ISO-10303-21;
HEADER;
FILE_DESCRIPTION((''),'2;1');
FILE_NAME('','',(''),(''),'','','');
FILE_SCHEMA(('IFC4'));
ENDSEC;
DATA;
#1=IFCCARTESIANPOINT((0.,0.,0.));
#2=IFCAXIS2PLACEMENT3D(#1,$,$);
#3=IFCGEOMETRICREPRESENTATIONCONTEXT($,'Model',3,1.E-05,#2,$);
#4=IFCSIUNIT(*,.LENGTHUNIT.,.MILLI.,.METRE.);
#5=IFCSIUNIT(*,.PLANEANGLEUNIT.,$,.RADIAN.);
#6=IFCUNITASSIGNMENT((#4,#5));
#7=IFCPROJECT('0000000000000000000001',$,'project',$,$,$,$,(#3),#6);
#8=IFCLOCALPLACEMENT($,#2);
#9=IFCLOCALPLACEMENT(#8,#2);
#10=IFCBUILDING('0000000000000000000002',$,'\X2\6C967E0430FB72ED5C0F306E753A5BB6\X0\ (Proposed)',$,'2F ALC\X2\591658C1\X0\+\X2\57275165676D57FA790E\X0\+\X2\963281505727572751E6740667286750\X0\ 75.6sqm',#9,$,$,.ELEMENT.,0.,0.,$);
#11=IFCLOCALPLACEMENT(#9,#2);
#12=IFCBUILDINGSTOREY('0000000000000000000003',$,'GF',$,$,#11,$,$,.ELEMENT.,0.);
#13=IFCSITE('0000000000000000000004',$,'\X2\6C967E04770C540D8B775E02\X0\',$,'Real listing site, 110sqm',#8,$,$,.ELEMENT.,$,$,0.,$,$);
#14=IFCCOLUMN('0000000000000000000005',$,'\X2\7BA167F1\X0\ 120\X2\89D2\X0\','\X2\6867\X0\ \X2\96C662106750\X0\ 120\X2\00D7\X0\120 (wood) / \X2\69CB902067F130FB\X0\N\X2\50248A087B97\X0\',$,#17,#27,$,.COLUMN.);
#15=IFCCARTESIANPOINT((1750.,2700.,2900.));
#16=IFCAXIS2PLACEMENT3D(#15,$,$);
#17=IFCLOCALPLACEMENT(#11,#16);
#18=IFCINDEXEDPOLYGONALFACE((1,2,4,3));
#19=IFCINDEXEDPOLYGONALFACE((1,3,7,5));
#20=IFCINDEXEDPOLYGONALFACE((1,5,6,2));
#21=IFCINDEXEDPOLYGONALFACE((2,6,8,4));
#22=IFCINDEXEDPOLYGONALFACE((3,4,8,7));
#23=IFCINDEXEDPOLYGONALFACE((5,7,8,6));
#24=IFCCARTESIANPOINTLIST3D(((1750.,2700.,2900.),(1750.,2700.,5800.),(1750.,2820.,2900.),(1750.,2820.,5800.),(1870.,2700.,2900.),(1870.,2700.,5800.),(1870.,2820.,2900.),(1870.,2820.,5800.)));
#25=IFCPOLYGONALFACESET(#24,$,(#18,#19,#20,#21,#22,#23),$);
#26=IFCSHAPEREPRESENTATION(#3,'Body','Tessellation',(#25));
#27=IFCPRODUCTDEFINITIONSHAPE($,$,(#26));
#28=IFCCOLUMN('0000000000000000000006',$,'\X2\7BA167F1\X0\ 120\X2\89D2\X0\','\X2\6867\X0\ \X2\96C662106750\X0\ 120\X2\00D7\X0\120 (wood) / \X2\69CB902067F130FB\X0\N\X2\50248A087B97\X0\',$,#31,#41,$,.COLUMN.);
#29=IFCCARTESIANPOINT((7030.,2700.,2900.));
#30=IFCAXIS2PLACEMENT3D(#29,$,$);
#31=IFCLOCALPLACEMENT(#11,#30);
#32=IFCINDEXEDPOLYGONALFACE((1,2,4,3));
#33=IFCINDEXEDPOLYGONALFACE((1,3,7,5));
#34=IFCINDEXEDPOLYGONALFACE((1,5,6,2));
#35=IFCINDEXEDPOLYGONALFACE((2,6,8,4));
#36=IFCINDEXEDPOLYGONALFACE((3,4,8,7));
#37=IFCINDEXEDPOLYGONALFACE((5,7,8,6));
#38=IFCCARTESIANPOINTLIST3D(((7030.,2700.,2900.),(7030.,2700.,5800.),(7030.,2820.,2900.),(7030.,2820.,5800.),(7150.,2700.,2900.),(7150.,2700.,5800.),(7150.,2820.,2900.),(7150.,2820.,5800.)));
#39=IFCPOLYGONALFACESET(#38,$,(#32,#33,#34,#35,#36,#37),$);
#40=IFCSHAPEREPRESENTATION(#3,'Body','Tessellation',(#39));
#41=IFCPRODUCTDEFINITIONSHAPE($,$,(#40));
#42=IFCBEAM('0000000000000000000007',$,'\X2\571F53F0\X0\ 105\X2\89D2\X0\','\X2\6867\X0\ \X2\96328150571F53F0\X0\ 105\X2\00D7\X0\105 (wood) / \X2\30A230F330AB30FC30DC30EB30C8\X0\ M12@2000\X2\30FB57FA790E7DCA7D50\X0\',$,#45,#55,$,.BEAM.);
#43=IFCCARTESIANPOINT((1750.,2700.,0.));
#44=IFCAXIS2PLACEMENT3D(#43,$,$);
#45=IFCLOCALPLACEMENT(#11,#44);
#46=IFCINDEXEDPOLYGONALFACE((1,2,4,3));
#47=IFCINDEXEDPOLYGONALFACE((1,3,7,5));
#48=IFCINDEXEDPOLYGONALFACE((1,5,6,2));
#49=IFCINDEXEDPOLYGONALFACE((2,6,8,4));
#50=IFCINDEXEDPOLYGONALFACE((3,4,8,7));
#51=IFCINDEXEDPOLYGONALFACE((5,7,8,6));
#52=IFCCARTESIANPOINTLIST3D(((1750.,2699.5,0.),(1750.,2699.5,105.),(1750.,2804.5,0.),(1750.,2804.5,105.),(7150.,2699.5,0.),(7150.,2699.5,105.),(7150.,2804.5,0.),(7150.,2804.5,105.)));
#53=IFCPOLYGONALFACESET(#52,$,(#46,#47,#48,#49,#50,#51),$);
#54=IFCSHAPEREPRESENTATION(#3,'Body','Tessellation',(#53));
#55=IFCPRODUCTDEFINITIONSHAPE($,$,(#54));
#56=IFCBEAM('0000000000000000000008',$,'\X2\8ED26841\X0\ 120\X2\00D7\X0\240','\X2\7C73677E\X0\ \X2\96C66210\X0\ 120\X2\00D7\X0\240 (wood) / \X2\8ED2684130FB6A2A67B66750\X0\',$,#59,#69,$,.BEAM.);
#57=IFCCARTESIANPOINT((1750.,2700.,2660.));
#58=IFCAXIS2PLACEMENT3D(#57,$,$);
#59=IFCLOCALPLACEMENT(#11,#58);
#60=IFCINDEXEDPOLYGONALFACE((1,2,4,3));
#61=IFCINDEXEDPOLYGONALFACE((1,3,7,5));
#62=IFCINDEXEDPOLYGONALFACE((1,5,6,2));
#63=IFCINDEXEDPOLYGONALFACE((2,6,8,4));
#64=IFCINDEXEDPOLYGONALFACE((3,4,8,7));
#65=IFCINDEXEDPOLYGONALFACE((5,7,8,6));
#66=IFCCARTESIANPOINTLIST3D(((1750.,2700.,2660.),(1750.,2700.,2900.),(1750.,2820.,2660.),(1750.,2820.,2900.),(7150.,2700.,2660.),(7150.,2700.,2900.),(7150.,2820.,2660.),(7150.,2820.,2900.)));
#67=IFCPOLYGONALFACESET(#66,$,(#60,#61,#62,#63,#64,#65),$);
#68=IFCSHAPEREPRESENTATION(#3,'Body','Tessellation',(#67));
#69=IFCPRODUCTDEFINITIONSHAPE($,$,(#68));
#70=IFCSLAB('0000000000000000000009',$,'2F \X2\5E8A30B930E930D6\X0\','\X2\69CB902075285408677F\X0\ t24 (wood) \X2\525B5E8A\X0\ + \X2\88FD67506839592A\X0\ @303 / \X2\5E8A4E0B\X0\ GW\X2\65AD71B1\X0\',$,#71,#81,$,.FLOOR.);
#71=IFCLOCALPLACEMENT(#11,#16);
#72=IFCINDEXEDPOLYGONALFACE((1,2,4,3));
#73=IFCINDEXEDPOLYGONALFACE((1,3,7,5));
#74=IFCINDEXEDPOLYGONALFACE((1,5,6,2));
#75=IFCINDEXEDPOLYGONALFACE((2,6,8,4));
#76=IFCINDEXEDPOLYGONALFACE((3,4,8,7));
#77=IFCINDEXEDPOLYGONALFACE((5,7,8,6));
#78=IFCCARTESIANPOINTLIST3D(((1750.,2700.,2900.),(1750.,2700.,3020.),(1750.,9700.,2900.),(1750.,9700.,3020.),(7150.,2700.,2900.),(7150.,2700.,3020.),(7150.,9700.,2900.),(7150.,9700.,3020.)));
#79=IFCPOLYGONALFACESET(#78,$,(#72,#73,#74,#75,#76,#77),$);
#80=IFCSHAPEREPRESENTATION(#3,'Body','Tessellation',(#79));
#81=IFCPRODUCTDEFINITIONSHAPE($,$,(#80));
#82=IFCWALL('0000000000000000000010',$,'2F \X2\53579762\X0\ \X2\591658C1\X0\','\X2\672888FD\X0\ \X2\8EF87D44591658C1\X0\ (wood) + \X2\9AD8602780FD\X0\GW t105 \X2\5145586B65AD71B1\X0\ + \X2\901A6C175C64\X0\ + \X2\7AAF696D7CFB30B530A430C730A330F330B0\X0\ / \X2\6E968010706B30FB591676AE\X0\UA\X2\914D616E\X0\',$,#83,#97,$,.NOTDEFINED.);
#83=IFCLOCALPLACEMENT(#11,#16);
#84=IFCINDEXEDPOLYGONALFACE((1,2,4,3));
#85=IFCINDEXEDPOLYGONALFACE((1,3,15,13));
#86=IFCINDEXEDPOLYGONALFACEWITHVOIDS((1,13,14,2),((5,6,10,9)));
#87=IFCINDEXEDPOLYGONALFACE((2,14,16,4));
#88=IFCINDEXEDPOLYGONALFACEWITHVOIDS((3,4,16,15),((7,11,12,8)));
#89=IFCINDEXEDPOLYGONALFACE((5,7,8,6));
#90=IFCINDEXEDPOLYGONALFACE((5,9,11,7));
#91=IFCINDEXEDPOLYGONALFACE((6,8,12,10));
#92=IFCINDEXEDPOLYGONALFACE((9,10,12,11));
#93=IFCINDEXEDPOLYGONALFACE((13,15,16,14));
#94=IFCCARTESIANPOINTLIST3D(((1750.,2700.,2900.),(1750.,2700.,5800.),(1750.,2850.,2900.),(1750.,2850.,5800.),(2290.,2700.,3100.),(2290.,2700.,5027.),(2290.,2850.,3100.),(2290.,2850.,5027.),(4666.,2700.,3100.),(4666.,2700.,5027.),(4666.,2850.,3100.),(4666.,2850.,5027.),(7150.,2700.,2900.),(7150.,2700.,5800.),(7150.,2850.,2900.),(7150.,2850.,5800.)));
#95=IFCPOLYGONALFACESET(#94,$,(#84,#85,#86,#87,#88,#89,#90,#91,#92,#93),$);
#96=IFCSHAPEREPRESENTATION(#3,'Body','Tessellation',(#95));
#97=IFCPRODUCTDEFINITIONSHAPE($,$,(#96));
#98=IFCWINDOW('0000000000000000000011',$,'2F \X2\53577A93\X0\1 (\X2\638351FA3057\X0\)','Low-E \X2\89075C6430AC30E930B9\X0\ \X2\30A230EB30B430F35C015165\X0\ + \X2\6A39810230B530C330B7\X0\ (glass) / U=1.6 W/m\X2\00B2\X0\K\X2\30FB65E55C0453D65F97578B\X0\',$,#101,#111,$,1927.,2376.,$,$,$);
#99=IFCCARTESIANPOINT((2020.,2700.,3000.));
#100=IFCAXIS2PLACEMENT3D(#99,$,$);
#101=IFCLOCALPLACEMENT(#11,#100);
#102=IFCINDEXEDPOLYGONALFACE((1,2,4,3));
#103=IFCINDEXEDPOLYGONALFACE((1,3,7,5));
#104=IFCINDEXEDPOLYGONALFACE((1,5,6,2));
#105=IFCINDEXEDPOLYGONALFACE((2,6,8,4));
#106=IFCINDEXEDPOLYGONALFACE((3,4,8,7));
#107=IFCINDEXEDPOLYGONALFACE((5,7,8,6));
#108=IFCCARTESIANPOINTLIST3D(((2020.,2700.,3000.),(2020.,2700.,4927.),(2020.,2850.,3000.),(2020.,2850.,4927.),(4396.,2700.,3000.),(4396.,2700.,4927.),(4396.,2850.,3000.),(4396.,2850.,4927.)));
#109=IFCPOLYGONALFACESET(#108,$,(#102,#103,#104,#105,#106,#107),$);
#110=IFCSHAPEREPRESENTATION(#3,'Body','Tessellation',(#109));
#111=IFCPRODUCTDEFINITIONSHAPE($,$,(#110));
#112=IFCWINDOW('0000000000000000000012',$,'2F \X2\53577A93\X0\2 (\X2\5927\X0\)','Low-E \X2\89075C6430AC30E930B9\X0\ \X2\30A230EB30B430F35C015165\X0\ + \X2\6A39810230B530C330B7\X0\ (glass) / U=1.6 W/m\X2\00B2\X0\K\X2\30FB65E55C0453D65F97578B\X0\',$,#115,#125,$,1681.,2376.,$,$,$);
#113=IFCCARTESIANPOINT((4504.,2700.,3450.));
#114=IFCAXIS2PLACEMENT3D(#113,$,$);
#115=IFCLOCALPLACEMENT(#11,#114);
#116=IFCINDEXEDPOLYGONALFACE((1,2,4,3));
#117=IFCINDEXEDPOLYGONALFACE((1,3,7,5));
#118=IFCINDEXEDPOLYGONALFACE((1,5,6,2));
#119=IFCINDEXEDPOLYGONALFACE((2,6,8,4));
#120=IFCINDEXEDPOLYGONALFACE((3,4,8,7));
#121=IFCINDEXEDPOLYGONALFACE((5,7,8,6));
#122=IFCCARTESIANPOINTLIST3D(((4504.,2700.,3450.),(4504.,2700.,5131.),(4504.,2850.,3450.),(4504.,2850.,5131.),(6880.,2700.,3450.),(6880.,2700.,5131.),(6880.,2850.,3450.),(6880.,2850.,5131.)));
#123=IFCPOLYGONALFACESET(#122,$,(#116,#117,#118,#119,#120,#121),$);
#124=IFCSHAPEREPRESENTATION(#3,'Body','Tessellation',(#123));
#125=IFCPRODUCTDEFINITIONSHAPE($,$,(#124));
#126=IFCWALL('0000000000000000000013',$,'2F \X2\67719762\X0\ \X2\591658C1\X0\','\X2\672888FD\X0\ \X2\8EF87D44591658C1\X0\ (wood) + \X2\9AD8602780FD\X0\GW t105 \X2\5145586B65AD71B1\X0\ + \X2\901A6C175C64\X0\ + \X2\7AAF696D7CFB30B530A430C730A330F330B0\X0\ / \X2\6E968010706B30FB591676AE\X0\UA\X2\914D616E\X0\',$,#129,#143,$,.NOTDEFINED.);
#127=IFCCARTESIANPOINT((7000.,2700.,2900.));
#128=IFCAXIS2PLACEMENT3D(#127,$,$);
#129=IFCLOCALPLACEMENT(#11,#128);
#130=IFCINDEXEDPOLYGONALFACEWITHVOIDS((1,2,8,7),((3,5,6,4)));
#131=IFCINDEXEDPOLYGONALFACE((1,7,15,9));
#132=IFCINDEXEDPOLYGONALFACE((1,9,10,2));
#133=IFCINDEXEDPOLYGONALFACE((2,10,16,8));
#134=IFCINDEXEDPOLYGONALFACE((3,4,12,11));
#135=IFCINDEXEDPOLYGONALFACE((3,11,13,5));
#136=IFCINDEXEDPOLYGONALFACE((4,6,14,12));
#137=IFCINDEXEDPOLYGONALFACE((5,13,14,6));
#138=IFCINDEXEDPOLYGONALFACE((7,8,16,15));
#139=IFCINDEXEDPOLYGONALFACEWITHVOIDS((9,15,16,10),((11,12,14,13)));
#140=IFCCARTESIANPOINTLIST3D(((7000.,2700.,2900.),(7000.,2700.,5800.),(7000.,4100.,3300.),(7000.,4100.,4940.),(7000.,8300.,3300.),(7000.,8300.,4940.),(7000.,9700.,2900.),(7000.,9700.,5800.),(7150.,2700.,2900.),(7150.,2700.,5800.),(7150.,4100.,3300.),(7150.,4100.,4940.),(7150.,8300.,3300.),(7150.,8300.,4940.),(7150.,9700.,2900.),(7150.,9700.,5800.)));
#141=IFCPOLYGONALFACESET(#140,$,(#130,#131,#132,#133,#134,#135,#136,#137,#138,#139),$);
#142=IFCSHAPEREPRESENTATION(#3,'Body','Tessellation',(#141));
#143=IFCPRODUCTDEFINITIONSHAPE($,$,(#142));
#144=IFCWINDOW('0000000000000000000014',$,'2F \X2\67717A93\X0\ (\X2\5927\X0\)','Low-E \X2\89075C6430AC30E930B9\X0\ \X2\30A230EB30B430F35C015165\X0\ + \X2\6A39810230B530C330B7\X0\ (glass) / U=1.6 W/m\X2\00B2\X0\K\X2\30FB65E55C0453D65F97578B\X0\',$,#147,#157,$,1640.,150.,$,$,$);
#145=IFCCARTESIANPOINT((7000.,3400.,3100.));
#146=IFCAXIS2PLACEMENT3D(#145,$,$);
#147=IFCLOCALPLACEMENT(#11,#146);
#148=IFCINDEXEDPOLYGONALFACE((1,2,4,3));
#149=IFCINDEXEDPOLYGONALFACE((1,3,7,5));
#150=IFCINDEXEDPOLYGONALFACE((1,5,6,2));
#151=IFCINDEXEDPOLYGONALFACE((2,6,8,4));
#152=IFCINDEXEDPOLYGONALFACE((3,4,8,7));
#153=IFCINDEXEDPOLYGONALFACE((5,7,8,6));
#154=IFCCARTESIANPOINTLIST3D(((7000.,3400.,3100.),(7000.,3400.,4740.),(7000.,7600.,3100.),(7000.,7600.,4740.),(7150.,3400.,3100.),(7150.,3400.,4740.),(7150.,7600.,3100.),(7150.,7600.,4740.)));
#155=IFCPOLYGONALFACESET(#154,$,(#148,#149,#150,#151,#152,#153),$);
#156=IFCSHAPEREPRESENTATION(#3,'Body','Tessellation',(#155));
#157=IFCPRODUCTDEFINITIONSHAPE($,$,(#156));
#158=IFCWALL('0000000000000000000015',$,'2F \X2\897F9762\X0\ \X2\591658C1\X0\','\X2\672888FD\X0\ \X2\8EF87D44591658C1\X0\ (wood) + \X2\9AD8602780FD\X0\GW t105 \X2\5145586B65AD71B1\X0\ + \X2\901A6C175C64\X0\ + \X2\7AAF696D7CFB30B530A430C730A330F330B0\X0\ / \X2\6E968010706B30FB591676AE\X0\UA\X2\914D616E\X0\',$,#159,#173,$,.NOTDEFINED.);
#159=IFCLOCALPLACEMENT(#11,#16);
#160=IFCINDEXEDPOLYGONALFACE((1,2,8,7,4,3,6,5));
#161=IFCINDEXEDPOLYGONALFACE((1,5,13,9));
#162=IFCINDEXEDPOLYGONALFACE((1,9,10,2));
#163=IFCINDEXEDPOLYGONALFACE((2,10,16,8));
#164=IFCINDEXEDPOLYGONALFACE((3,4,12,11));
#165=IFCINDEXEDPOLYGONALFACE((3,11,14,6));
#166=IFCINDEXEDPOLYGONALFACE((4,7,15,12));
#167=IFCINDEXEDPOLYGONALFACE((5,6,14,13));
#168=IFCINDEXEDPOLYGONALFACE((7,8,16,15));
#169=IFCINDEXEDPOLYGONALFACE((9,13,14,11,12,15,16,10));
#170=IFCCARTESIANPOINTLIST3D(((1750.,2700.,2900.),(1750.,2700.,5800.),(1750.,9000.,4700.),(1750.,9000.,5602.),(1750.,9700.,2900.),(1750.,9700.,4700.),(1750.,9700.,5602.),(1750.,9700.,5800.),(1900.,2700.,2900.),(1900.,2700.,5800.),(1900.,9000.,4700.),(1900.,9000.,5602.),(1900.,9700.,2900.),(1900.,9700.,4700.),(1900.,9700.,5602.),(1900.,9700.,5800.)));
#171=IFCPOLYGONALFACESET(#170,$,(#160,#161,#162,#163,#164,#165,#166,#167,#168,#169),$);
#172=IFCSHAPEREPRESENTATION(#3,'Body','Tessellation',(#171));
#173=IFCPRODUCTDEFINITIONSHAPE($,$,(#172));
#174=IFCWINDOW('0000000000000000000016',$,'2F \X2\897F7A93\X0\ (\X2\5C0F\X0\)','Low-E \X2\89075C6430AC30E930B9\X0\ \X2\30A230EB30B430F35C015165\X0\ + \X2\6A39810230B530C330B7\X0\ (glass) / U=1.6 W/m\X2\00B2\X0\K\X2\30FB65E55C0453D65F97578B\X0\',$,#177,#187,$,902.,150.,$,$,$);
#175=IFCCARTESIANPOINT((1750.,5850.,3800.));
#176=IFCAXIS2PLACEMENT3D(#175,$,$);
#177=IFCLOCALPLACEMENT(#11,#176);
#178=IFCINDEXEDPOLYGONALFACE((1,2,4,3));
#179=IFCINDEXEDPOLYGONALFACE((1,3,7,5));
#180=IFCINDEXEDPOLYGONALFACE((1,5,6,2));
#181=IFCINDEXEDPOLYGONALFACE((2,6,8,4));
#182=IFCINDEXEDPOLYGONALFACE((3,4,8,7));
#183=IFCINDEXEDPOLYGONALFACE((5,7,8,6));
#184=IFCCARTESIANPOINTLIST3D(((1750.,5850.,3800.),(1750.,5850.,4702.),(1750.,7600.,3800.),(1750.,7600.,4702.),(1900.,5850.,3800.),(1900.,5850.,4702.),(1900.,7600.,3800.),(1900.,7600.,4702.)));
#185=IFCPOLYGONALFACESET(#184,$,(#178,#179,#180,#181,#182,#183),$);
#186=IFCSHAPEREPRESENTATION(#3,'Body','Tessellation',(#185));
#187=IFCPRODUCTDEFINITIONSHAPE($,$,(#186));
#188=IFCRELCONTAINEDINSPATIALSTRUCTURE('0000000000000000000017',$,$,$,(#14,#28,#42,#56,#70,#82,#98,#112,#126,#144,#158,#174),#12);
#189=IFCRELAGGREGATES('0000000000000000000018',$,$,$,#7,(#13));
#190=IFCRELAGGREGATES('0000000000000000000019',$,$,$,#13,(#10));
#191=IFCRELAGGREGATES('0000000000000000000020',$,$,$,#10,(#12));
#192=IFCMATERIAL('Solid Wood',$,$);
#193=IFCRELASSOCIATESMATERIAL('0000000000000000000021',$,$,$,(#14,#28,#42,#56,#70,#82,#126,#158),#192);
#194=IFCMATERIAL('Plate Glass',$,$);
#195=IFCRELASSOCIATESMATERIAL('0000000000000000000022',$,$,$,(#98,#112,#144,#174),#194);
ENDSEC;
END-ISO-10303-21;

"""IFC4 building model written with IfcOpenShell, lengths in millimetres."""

from ifc_helpers import new_model, si_unit, frame, frame_2d, origin, place, context, project, spatial, rectangle, extrude, material, element, fill, save


model = new_model("IFC4")

# Units and contexts
model_context = context("Model", 3, precision=1e-05, world=origin())
ifc_project = project(units=[si_unit("LENGTHUNIT", "METRE", prefix="MILLI"), si_unit("PLANEANGLEUNIT", "RADIAN")], contexts=[model_context])

# Site, building, storey
site_placement = place(None, origin())
site = spatial("IfcSite", under=ifc_project, at=site_placement, Name="沖縄県名護市", ObjectType="Real listing site, 110sqm", CompositionType="ELEMENT", RefElevation=0.0)
building_placement = place(site_placement, origin())
building = spatial("IfcBuilding", under=site, at=building_placement, Name="沖縄・狭小の町家 (Proposed)", ObjectType="2F ALC外壁+圧入杭基礎+防腐圧圧処理木材 75.6sqm", CompositionType="ELEMENT", ElevationOfRefHeight=0.0, ElevationOfTerrain=0.0)
storey_placement = place(building_placement, origin())
storey = spatial("IfcBuildingStorey", under=building, at=storey_placement, Name="GF", CompositionType="ELEMENT", Elevation=0.0)

# Columns
ifc_material_1 = material(Name="Solid Wood")
column_1_placement = place(storey_placement, frame((1750.0, 2700.0, 2900.0)))
element("IfcColumn", 1, at=column_1_placement, inside=storey, material=ifc_material_1, Name="管柱 120角", Description="桧 集成材 120×120 (wood) / 構造柱・N値計算", PredefinedType="COLUMN", context=model_context, shape_type="SweptSolid", body=[
    extrude(rectangle(XDim=120.0, YDim=120.0, at=frame_2d((60.0, 60.0))), frame((1750.0, 2700.0, 2900.0)), (0.0, 0.0, 1.0), 2900.0),
])
column_2_placement = place(storey_placement, frame((7030.0, 2700.0, 2900.0)))
element("IfcColumn", 2, at=column_2_placement, inside=storey, material=ifc_material_1, Name="管柱 120角", Description="桧 集成材 120×120 (wood) / 構造柱・N値計算", PredefinedType="COLUMN", context=model_context, shape_type="SweptSolid", body=[
    extrude(rectangle(XDim=120.0, YDim=120.0, at=frame_2d((60.0, 60.0))), frame((7030.0, 2700.0, 2900.0)), (0.0, 0.0, 1.0), 2900.0),
])

# Beams
beam_1_placement = place(storey_placement, frame((1750.0, 2700.0, 0.0)))
element("IfcBeam", 3, at=beam_1_placement, inside=storey, material=ifc_material_1, Name="土台 105角", Description="桧 防腐土台 105×105 (wood) / アンカーボルト M12@2000・基礎緊結", PredefinedType="BEAM", context=model_context, shape_type="SweptSolid", body=[
    extrude(rectangle(XDim=5400.0, YDim=105.0, at=frame_2d((2700.0, 52.0))), frame((1750.0, 2700.0, 0.0)), (0.0, 0.0, 1.0), 105.0),
])
beam_2_placement = place(storey_placement, frame((1750.0, 2700.0, 2660.0)))
element("IfcBeam", 4, at=beam_2_placement, inside=storey, material=ifc_material_1, Name="軒桁 120×240", Description="米松 集成 120×240 (wood) / 軒桁・横架材", PredefinedType="BEAM", context=model_context, shape_type="SweptSolid", body=[
    extrude(rectangle(XDim=5400.0, YDim=120.0, at=frame_2d((2700.0, 60.0))), frame((1750.0, 2700.0, 2660.0)), (0.0, 0.0, 1.0), 240.0),
])

# Slab
slab_placement = place(storey_placement, frame((1750.0, 2700.0, 2900.0)))
element("IfcSlab", 5, at=slab_placement, inside=storey, material=ifc_material_1, Name="2F 床スラブ", Description="構造用合板 t24 (wood) 剛床 + 製材根太 @303 / 床下 GW断熱", PredefinedType="FLOOR", context=model_context, shape_type="SweptSolid", body=[
    extrude(rectangle(XDim=5400.0, YDim=7000.0, at=frame_2d((2700.0, 3500.0))), frame((1750.0, 2700.0, 2900.0)), (0.0, 0.0, 1.0), 120.0),
])

# Wall, openings, windows
wall_1_placement = place(storey_placement, frame((1750.0, 2700.0, 2900.0)))
wall_1 = element("IfcWall", 6, at=wall_1_placement, inside=storey, material=ifc_material_1, Name="2F 南面 外壁", Description="木製 軸組外壁 (wood) + 高性能GW t105 充填断熱 + 通気層 + 窯業系サイディング / 準耐火・外皮UA配慮", PredefinedType="NOTDEFINED", context=model_context, shape_type="SweptSolid", body=[
    extrude(rectangle(XDim=5400.0, YDim=150.0, at=frame_2d((2700.0, 75.0))), frame((1750.0, 2700.0, 2900.0)), (0.0, 0.0, 1.0), 2900.0),
])
opening_1_placement = place(storey_placement, frame((2020.0, 2700.0, 3000.0)))
opening_1 = element("IfcOpeningElement", 7, at=opening_1_placement, cuts=wall_1, PredefinedType="NOTDEFINED", context=model_context, shape_type="SweptSolid", body=[
    extrude(rectangle(XDim=2376.0, YDim=150.0, at=frame_2d((1188.0, 75.0))), frame((2020.0, 2700.0, 3000.0)), (0.0, 0.0, 1.0), 1927.0),
])
opening_2_placement = place(storey_placement, frame((4504.0, 2700.0, 3450.0)))
opening_2 = element("IfcOpeningElement", 8, at=opening_2_placement, cuts=wall_1, PredefinedType="NOTDEFINED", context=model_context, shape_type="SweptSolid", body=[
    extrude(rectangle(XDim=2376.0, YDim=150.0, at=frame_2d((1188.0, 75.0))), frame((4504.0, 2700.0, 3450.0)), (0.0, 0.0, 1.0), 1681.0),
])
ifc_material_2 = material(Name="Plate Glass")
window_1_placement = place(storey_placement, frame((2020.0, 2700.0, 3000.0)))
window_1 = element("IfcWindow", 9, at=window_1_placement, inside=storey, material=ifc_material_2, Name="2F 南窓1 (掃出し)", Description="Low-E 複層ガラス アルゴン封入 + 樹脂サッシ (glass) / U=1.6 W/m²K・日射取得型", OverallHeight=1927.0, OverallWidth=2376.0, context=model_context, shape_type="SweptSolid", body=[
    extrude(rectangle(XDim=2376.0, YDim=150.0, at=frame_2d((1188.0, 75.0))), frame((2020.0, 2700.0, 3000.0)), (0.0, 0.0, 1.0), 1927.0),
])
fill(opening_1, window_1)
window_2_placement = place(storey_placement, frame((4504.0, 2700.0, 3450.0)))
window_2 = element("IfcWindow", 10, at=window_2_placement, inside=storey, material=ifc_material_2, Name="2F 南窓2 (大)", Description="Low-E 複層ガラス アルゴン封入 + 樹脂サッシ (glass) / U=1.6 W/m²K・日射取得型", OverallHeight=1681.0, OverallWidth=2376.0, context=model_context, shape_type="SweptSolid", body=[
    extrude(rectangle(XDim=2376.0, YDim=150.0, at=frame_2d((1188.0, 75.0))), frame((4504.0, 2700.0, 3450.0)), (0.0, 0.0, 1.0), 1681.0),
])
fill(opening_2, window_2)

# Walls, openings, windows
wall_2_placement = place(storey_placement, frame((7000.0, 2700.0, 2900.0)))
wall_2 = element("IfcWall", 11, at=wall_2_placement, inside=storey, material=ifc_material_1, Name="2F 東面 外壁", Description="木製 軸組外壁 (wood) + 高性能GW t105 充填断熱 + 通気層 + 窯業系サイディング / 準耐火・外皮UA配慮", PredefinedType="NOTDEFINED", context=model_context, shape_type="SweptSolid", body=[
    extrude(rectangle(XDim=150.0, YDim=7000.0, at=frame_2d((75.0, 3500.0))), frame((7000.0, 2700.0, 2900.0)), (0.0, 0.0, 1.0), 2900.0),
])
opening_3_placement = place(storey_placement, frame((7000.0, 3400.0, 3100.0)))
opening_3 = element("IfcOpeningElement", 12, at=opening_3_placement, cuts=wall_2, PredefinedType="NOTDEFINED", context=model_context, shape_type="SweptSolid", body=[
    extrude(rectangle(XDim=150.0, YDim=4200.0, at=frame_2d((75.0, 2100.0))), frame((7000.0, 3400.0, 3100.0)), (0.0, 0.0, 1.0), 1640.0),
])
window_3_placement = place(storey_placement, frame((7000.0, 3400.0, 3100.0)))
window_3 = element("IfcWindow", 13, at=window_3_placement, inside=storey, material=ifc_material_2, Name="2F 東窓 (大)", Description="Low-E 複層ガラス アルゴン封入 + 樹脂サッシ (glass) / U=1.6 W/m²K・日射取得型", OverallHeight=1640.0, OverallWidth=150.0, context=model_context, shape_type="SweptSolid", body=[
    extrude(rectangle(XDim=150.0, YDim=4200.0, at=frame_2d((75.0, 2100.0))), frame((7000.0, 3400.0, 3100.0)), (0.0, 0.0, 1.0), 1640.0),
])
fill(opening_3, window_3)
wall_3_placement = place(storey_placement, frame((1750.0, 2700.0, 2900.0)))
wall_3 = element("IfcWall", 14, at=wall_3_placement, inside=storey, material=ifc_material_1, Name="2F 西面 外壁", Description="木製 軸組外壁 (wood) + 高性能GW t105 充填断熱 + 通気層 + 窯業系サイディング / 準耐火・外皮UA配慮", PredefinedType="NOTDEFINED", context=model_context, shape_type="SweptSolid", body=[
    extrude(rectangle(XDim=150.0, YDim=7000.0, at=frame_2d((75.0, 3500.0))), frame((1750.0, 2700.0, 2900.0)), (0.0, 0.0, 1.0), 2900.0),
])
opening_4_placement = place(storey_placement, frame((1750.0, 5850.0, 3800.0)))
opening_4 = element("IfcOpeningElement", 15, at=opening_4_placement, cuts=wall_3, PredefinedType="NOTDEFINED", context=model_context, shape_type="SweptSolid", body=[
    extrude(rectangle(XDim=150.0, YDim=1750.0, at=frame_2d((75.0, 875.0))), frame((1750.0, 5850.0, 3800.0)), (0.0, 0.0, 1.0), 902.0),
])
window_4_placement = place(storey_placement, frame((1750.0, 5850.0, 3800.0)))
window_4 = element("IfcWindow", 16, at=window_4_placement, inside=storey, material=ifc_material_2, Name="2F 西窓 (小)", Description="Low-E 複層ガラス アルゴン封入 + 樹脂サッシ (glass) / U=1.6 W/m²K・日射取得型", OverallHeight=902.0, OverallWidth=150.0, context=model_context, shape_type="SweptSolid", body=[
    extrude(rectangle(XDim=150.0, YDim=1750.0, at=frame_2d((75.0, 875.0))), frame((1750.0, 5850.0, 3800.0)), (0.0, 0.0, 1.0), 902.0),
])
fill(opening_4, window_4)

save(model, "model.ifc")
